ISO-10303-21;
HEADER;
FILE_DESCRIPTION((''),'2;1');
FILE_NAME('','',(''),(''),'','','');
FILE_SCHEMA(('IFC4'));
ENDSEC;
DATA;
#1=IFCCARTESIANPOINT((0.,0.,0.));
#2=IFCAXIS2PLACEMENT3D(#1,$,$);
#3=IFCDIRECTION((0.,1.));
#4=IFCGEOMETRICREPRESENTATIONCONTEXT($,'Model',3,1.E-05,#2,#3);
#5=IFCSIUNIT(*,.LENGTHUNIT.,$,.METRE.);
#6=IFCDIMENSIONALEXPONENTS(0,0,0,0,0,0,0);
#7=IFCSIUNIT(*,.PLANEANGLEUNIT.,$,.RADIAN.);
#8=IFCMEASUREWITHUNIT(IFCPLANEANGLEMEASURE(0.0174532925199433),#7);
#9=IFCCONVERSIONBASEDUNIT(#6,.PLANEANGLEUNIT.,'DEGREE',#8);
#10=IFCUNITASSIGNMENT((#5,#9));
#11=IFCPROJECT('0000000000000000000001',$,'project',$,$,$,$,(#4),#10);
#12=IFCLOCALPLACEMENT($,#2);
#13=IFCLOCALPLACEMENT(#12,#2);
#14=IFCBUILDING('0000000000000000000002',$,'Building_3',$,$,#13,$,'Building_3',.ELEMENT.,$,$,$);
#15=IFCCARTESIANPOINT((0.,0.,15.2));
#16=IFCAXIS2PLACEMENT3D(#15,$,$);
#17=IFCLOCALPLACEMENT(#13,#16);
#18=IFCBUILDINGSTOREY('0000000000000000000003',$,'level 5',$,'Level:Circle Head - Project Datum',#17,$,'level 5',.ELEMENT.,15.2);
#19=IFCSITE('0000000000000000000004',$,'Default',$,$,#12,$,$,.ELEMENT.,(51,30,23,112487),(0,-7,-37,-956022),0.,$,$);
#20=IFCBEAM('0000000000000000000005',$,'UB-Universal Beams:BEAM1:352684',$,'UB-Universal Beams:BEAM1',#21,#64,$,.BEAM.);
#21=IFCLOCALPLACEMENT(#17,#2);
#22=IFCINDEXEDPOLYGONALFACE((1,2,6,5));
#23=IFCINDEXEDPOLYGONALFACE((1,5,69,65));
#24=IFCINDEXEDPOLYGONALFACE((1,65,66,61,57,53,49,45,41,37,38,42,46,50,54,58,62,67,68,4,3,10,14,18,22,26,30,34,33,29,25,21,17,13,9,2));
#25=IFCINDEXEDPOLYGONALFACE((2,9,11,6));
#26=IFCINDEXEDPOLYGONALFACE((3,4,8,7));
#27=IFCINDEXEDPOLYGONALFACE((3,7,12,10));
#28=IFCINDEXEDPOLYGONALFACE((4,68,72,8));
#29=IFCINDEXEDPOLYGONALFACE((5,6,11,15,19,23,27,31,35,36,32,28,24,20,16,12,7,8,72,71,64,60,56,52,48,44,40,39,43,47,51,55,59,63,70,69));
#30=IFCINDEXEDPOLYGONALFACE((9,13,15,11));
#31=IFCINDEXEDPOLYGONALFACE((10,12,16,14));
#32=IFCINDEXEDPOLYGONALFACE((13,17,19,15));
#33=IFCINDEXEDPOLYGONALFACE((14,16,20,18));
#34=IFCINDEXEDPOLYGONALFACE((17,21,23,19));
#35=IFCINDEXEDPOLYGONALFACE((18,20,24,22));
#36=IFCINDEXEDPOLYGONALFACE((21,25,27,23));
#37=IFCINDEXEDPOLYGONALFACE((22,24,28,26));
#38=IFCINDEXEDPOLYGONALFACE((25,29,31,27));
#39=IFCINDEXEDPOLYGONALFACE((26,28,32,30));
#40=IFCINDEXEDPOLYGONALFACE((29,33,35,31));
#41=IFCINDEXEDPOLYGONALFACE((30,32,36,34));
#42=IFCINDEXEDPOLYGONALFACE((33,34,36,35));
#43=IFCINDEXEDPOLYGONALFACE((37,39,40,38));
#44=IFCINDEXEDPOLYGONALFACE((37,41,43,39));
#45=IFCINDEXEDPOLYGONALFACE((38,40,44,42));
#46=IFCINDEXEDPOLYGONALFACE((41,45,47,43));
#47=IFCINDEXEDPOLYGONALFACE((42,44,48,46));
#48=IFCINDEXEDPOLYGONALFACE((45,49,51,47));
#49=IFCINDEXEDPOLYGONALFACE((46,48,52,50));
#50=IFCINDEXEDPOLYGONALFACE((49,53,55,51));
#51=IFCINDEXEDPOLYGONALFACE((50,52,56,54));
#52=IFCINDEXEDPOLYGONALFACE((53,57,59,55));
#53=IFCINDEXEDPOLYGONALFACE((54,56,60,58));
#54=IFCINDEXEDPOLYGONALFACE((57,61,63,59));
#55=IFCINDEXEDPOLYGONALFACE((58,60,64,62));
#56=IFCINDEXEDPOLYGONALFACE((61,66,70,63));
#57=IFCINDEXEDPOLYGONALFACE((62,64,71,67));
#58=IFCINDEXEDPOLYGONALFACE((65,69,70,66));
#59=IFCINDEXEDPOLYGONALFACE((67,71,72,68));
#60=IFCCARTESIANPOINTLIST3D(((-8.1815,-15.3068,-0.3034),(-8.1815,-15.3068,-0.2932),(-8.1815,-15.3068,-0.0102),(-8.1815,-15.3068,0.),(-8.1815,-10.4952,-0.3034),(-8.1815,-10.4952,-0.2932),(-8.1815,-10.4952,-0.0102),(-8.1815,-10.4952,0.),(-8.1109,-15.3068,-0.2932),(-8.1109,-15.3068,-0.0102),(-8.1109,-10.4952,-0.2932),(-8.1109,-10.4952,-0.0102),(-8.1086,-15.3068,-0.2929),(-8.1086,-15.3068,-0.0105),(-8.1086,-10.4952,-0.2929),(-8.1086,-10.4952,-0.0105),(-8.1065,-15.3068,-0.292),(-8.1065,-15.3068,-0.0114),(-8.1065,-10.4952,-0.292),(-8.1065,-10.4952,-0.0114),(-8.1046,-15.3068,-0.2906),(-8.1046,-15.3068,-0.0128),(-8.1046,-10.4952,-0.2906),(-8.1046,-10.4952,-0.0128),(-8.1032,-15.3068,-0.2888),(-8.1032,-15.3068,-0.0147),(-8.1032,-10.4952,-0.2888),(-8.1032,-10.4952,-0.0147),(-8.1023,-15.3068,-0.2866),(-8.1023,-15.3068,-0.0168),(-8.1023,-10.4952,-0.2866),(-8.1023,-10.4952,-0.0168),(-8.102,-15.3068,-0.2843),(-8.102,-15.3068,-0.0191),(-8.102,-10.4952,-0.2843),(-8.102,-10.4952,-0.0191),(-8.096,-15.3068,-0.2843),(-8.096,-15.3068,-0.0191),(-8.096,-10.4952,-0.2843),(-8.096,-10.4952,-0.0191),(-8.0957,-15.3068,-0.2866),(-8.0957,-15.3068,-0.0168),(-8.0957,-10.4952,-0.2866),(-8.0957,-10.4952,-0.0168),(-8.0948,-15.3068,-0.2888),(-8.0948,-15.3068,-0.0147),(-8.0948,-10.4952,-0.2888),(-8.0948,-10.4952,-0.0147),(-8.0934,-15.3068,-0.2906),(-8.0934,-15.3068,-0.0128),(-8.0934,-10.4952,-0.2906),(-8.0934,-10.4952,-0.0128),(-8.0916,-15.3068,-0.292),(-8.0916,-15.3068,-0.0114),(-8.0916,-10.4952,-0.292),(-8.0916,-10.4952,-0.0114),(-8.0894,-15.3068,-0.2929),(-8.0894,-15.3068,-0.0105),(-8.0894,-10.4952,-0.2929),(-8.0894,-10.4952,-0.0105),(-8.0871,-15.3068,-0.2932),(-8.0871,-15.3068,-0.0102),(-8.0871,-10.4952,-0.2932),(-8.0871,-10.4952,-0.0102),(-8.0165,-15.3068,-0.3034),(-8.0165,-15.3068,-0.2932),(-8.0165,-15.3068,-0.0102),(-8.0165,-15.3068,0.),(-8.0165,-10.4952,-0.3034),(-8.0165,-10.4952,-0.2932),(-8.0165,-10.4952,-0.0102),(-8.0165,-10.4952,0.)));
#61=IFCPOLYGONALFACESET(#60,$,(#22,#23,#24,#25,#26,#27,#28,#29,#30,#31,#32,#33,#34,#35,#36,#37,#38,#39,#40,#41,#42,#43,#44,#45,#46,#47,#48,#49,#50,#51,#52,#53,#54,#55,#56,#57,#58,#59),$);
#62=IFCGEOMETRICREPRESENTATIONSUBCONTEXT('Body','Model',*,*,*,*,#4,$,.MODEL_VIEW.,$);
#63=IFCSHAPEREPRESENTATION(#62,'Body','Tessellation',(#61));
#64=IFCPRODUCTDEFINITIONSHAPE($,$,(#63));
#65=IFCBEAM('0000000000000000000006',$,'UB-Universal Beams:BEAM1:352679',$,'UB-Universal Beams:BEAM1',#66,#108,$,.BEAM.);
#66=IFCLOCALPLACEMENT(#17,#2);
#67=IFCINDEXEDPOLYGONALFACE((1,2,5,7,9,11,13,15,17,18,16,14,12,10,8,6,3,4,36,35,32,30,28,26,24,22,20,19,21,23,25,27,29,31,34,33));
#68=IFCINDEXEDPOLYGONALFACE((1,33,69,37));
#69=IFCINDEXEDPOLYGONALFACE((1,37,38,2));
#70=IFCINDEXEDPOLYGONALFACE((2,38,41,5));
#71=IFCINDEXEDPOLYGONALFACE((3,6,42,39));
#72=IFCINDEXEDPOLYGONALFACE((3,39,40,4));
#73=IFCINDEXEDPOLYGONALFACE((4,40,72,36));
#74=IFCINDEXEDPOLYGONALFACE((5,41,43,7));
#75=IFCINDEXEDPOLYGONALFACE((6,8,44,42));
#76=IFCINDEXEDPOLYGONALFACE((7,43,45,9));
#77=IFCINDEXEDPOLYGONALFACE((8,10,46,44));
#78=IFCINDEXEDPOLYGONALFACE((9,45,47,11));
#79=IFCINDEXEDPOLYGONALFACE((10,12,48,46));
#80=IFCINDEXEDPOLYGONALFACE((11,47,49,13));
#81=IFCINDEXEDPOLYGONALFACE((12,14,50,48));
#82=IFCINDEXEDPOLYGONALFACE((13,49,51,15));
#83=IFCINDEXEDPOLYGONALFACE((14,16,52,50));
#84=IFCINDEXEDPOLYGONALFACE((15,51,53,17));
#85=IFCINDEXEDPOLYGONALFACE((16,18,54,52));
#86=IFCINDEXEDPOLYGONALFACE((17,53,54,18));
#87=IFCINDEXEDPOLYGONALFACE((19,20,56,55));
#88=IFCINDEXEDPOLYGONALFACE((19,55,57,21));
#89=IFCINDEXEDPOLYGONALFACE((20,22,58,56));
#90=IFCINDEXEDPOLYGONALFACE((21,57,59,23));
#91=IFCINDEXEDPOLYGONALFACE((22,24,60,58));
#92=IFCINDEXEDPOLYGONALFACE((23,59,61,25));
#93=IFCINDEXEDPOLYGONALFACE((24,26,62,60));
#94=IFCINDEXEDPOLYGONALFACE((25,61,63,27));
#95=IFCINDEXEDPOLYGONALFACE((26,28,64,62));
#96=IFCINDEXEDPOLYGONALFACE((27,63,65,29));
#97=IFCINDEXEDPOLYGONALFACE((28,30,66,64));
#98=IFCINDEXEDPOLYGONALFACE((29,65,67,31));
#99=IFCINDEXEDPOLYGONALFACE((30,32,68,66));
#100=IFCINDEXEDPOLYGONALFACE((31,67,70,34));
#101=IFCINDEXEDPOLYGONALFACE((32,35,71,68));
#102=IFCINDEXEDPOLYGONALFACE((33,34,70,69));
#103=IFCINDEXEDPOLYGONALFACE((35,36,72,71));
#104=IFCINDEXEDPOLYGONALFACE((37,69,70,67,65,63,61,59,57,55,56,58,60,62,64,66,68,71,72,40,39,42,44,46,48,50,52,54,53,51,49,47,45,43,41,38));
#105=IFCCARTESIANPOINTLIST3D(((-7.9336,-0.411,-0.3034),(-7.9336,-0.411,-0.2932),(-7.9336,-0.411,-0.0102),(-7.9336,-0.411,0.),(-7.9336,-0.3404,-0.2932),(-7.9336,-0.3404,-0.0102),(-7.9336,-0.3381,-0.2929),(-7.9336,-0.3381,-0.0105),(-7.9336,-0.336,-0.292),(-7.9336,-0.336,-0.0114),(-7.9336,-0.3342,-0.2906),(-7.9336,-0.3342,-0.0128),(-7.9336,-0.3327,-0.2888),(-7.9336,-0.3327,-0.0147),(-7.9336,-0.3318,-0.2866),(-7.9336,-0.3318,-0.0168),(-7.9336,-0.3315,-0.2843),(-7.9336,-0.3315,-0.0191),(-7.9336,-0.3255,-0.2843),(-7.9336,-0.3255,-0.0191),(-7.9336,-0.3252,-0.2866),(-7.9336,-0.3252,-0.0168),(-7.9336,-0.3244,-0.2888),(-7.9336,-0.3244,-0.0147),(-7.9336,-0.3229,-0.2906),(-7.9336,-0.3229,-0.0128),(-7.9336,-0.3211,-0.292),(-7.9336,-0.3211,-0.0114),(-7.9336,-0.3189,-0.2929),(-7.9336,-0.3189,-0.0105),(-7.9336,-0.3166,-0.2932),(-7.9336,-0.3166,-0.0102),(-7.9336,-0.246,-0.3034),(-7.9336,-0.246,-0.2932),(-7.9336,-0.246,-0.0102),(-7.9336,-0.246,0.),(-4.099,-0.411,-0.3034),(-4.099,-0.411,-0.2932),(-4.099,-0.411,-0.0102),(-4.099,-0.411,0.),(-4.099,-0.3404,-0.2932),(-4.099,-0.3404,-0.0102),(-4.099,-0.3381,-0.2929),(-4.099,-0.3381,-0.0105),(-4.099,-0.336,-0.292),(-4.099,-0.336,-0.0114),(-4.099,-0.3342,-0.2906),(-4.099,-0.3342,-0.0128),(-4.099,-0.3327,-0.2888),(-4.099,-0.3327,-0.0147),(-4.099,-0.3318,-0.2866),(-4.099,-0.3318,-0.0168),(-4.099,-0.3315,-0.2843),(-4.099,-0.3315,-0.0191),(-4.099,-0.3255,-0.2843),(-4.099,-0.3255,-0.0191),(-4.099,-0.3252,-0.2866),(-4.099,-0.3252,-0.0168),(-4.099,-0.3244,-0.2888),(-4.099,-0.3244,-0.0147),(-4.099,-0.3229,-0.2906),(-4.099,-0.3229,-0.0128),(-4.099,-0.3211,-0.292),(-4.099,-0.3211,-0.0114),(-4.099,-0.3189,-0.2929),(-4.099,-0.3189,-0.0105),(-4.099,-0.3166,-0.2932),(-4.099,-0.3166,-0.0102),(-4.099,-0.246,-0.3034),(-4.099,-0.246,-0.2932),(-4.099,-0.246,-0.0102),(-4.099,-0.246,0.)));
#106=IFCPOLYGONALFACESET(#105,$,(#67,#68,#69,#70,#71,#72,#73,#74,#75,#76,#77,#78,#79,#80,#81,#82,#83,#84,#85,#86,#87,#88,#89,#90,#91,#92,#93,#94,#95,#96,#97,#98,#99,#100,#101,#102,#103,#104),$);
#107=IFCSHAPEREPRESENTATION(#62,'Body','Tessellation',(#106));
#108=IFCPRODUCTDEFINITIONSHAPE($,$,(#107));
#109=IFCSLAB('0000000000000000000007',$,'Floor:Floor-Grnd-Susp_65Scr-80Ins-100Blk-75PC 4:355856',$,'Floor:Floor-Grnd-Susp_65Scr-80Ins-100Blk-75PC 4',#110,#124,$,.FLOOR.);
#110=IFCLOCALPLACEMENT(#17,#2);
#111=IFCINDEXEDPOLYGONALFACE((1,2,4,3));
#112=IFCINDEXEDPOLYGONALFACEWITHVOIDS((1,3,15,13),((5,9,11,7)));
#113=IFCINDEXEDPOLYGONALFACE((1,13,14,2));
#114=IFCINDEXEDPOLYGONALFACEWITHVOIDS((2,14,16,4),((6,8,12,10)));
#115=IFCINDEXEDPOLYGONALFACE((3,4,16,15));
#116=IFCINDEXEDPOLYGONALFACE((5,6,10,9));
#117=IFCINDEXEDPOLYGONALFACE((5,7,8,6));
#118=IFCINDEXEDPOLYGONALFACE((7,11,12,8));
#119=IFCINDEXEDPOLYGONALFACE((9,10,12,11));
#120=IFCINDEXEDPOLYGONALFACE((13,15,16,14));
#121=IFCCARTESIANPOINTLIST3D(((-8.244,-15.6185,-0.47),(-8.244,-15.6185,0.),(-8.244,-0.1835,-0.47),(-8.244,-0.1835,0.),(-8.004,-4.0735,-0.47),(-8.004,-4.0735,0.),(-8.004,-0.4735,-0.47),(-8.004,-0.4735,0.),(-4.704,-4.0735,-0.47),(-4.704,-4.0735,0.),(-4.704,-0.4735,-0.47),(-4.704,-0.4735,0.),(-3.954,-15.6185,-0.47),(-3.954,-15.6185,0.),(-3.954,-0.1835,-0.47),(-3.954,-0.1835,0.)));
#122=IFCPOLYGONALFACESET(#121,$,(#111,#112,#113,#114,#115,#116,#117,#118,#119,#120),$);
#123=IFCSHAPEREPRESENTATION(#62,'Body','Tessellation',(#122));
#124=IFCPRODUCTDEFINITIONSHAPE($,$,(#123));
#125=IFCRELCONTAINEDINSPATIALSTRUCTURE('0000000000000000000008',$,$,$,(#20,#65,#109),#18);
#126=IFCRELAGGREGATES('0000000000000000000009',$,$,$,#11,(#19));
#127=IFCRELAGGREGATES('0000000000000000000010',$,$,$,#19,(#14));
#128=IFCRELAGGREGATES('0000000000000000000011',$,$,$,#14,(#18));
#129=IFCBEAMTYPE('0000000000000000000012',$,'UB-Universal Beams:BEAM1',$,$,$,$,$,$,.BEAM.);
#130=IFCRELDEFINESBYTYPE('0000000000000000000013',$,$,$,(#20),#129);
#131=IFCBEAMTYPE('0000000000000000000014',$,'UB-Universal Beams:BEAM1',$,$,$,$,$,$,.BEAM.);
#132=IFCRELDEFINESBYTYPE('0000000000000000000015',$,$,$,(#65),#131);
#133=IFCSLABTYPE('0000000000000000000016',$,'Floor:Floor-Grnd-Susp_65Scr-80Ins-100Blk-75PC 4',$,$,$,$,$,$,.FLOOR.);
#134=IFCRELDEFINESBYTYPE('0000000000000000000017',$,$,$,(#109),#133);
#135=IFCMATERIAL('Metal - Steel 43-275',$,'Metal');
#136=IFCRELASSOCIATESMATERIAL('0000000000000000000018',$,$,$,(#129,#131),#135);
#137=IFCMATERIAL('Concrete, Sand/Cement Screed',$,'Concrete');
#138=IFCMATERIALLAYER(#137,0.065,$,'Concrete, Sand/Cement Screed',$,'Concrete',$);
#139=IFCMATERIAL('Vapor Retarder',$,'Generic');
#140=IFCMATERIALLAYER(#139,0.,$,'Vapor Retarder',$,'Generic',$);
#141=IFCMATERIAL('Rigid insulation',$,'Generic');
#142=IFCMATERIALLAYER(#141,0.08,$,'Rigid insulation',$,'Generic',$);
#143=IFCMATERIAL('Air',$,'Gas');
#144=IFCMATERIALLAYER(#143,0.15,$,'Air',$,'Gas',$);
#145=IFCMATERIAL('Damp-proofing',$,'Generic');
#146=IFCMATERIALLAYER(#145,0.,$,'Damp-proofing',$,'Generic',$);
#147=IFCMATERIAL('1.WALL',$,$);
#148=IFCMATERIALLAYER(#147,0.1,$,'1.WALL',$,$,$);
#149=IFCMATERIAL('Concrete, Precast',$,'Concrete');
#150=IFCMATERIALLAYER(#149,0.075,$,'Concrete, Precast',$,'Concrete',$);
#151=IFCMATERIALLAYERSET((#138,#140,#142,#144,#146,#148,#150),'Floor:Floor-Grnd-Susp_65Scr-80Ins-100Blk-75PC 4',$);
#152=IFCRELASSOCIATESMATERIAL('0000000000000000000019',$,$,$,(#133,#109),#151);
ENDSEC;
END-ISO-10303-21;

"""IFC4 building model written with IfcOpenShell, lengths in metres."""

from ifc_helpers import new_model, entity, si_unit, converted_unit, direction, frame, frame_2d, origin, place, context, subcontext, project, spatial, polyline, circle_curve, parameter, trimmed, segment, composite_curve, rectangle, outline, extrude, boolean, source, transform, mapped, material, layer, layer_set, layer_usage, material_profile, profile_set, type_object, type_shapes, element, save


model = new_model("IFC4")

# Units and contexts
model_context = context("Model", 3, precision=1e-05, world=origin(), true_north=direction((0.0, 1.0)))
body_context = subcontext(model_context, "Body", "Model", "MODEL_VIEW")
ifc_project = project(units=[si_unit("LENGTHUNIT", "METRE"), converted_unit("PLANEANGLEUNIT", "DEGREE", entity("IfcPlaneAngleMeasure", 0.0174532925199433), si_unit("PLANEANGLEUNIT", "RADIAN"), dimensions=[0, 0, 0, 0, 0, 0, 0])], contexts=[model_context])

# Site, building, storey
site_placement = place(None, origin())
site = spatial("IfcSite", under=ifc_project, at=site_placement, Name="Default", CompositionType="ELEMENT", RefLatitude=(51, 30, 23, 112487), RefLongitude=(0, -7, -37, -956022), RefElevation=0.0)
building_placement = place(site_placement, origin())
building = spatial("IfcBuilding", under=site, at=building_placement, Name="Building_3", LongName="Building_3", CompositionType="ELEMENT")
storey_placement = place(building_placement, frame((0.0, 0.0, 15.2)))
storey = spatial("IfcBuildingStorey", under=building, at=storey_placement, Name="level 5", ObjectType="Level:Circle Head - Project Datum", LongName="level 5", CompositionType="ELEMENT", Elevation=15.2)

# Beams
ifc_material_1 = material(Name="Metal - Steel 43-275", Category="Metal")
ifc_material_profile = material_profile(ifc_material_1, outline(composite_curve([segment(polyline([(-0.0825, -0.1415), (-0.0825, -0.1517)]), True, "CONTINUOUS"), segment(polyline([(-0.0825, -0.1517), (0.0825, -0.1517)]), True, "CONTINUOUS"), segment(polyline([(0.0825, -0.1517), (0.0825, -0.1415)]), True, "CONTINUOUS"), segment(polyline([(0.0825, -0.1415), (0.0119, -0.1415)]), True, "CONTINUOUS"), segment(trimmed(circle_curve(frame_2d((0.0119, -0.1326), x_axis=(1.0, 0.0)), 0.0089), [parameter(180.0)], [parameter(270.0)], True, "PARAMETER"), False, "CONTINUOUS"), segment(polyline([(0.003, -0.1326), (0.003, 0.1326)]), True, "CONTINUOUS"), segment(trimmed(circle_curve(frame_2d((0.0119, 0.1326), x_axis=(1.0, 0.0)), 0.0089), [parameter(90.0)], [parameter(180.0)], True, "PARAMETER"), False, "CONTINUOUS"), segment(polyline([(0.0119, 0.1415), (0.0825, 0.1415)]), True, "CONTINUOUS"), segment(polyline([(0.0825, 0.1415), (0.0825, 0.1517)]), True, "CONTINUOUS"), segment(polyline([(0.0825, 0.1517), (-0.0825, 0.1517)]), True, "CONTINUOUS"), segment(polyline([(-0.0825, 0.1517), (-0.0825, 0.1415)]), True, "CONTINUOUS"), segment(polyline([(-0.0825, 0.1415), (-0.0119, 0.1415)]), True, "CONTINUOUS"), segment(trimmed(circle_curve(frame_2d((-0.0119, 0.1326), x_axis=(1.0, 0.0)), 0.0089), [parameter(360.0)], [parameter(90.0)], True, "PARAMETER"), False, "CONTINUOUS"), segment(polyline([(-0.003, 0.1326), (-0.003, -0.1326)]), True, "CONTINUOUS"), segment(trimmed(circle_curve(frame_2d((-0.0119, -0.1326), x_axis=(1.0, 0.0)), 0.0089), [parameter(270.0)], [parameter(360.0)], True, "PARAMETER"), False, "CONTINUOUS"), segment(polyline([(-0.0119, -0.1415), (-0.0825, -0.1415)]), True, "CONTINUOUS")], self_intersect=False)), Name="BEAM1")
ifc_profile_set = profile_set([ifc_material_profile], Name="BEAM1")
beam_type_1 = type_object("IfcBeamType", Name="UB-Universal Beams:BEAM1", PredefinedType="BEAM", material=ifc_profile_set)
shared_shape_1 = source(origin(), body_context, "Body", "SweptSolid", [
    extrude(outline(composite_curve([segment(polyline([(-0.0825, -0.1415), (-0.0825, -0.1517)]), True, "CONTINUOUS"), segment(polyline([(-0.0825, -0.1517), (0.0825, -0.1517)]), True, "CONTINUOUS"), segment(polyline([(0.0825, -0.1517), (0.0825, -0.1415)]), True, "CONTINUOUS"), segment(polyline([(0.0825, -0.1415), (0.0119, -0.1415)]), True, "CONTINUOUS"), segment(trimmed(circle_curve(frame_2d((0.0119, -0.1326), x_axis=(0.0, -1.0)), 0.0089), [parameter(270.0)], [parameter(360.0)], True, "PARAMETER"), False, "CONTINUOUS"), segment(polyline([(0.003, -0.1326), (0.003, 0.1326)]), True, "CONTINUOUS"), segment(trimmed(circle_curve(frame_2d((0.0119, 0.1326), x_axis=(-1.0, 0.0)), 0.0089), [parameter(270.0)], [parameter(360.0)], True, "PARAMETER"), False, "CONTINUOUS"), segment(polyline([(0.0119, 0.1415), (0.0825, 0.1415)]), True, "CONTINUOUS"), segment(polyline([(0.0825, 0.1415), (0.0825, 0.1517)]), True, "CONTINUOUS"), segment(polyline([(0.0825, 0.1517), (-0.0825, 0.1517)]), True, "CONTINUOUS"), segment(polyline([(-0.0825, 0.1517), (-0.0825, 0.1415)]), True, "CONTINUOUS"), segment(polyline([(-0.0825, 0.1415), (-0.0119, 0.1415)]), True, "CONTINUOUS"), segment(trimmed(circle_curve(frame_2d((-0.0119, 0.1326), x_axis=(0.0, 1.0)), 0.0089), [parameter(270.0)], [parameter(360.0)], True, "PARAMETER"), False, "CONTINUOUS"), segment(polyline([(-0.003, 0.1326), (-0.003, -0.1326)]), True, "CONTINUOUS"), segment(trimmed(circle_curve(frame_2d((-0.0119, -0.1326), x_axis=(1.0, 0.0)), 0.0089), [parameter(270.0)], [parameter(0.0)], True, "PARAMETER"), False, "CONTINUOUS"), segment(polyline([(-0.0119, -0.1415), (-0.0825, -0.1415)]), True, "CONTINUOUS")], self_intersect=False)), frame((-2.4058, 0.0, 0.0), z_axis=(-1.0, 0.0, 0.0), x_axis=(0.0, -1.0, 0.0)), (0.0, 0.0, -1.0), 4.8116),
])
type_shapes(beam_type_1, [shared_shape_1])
for number, where, z_axis, x_axis, name in (
    (1, (-8.099, -12.901, -0.1517), (0.0, 0.0, 1.0), (0.0, 1.0, 0.0), "UB-Universal Beams:BEAM1:352684"),
):
    element("IfcBeam", number, at=place(storey_placement, frame(where, z_axis=z_axis, x_axis=x_axis)), inside=storey, type_object=beam_type_1, Name=name, ObjectType="UB-Universal Beams:BEAM1", PredefinedType="BEAM", context=body_context, shape_type="MappedRepresentation", body=[
        mapped(shared_shape_1, transform((0.0, 0.0, 0.0), scale=1.0)),
    ])
beam_type_2 = type_object("IfcBeamType", Name="UB-Universal Beams:BEAM1", PredefinedType="BEAM", material=ifc_profile_set)
shared_shape_2 = source(origin(), body_context, "Body", "SweptSolid", [
    extrude(outline(composite_curve([segment(polyline([(-0.0825, -0.1415), (-0.0825, -0.1517)]), True, "CONTINUOUS"), segment(polyline([(-0.0825, -0.1517), (0.0825, -0.1517)]), True, "CONTINUOUS"), segment(polyline([(0.0825, -0.1517), (0.0825, -0.1415)]), True, "CONTINUOUS"), segment(polyline([(0.0825, -0.1415), (0.0119, -0.1415)]), True, "CONTINUOUS"), segment(trimmed(circle_curve(frame_2d((0.0119, -0.1326), x_axis=(1.0, 0.0)), 0.0089), [parameter(180.0)], [parameter(270.0)], True, "PARAMETER"), False, "CONTINUOUS"), segment(polyline([(0.003, -0.1326), (0.003, 0.1326)]), True, "CONTINUOUS"), segment(trimmed(circle_curve(frame_2d((0.0119, 0.1326), x_axis=(1.0, 0.0)), 0.0089), [parameter(90.0)], [parameter(180.0)], True, "PARAMETER"), False, "CONTINUOUS"), segment(polyline([(0.0119, 0.1415), (0.0825, 0.1415)]), True, "CONTINUOUS"), segment(polyline([(0.0825, 0.1415), (0.0825, 0.1517)]), True, "CONTINUOUS"), segment(polyline([(0.0825, 0.1517), (-0.0825, 0.1517)]), True, "CONTINUOUS"), segment(polyline([(-0.0825, 0.1517), (-0.0825, 0.1415)]), True, "CONTINUOUS"), segment(polyline([(-0.0825, 0.1415), (-0.0119, 0.1415)]), True, "CONTINUOUS"), segment(trimmed(circle_curve(frame_2d((-0.0119, 0.1326), x_axis=(1.0, 0.0)), 0.0089), [parameter(360.0)], [parameter(90.0)], True, "PARAMETER"), False, "CONTINUOUS"), segment(polyline([(-0.003, 0.1326), (-0.003, -0.1326)]), True, "CONTINUOUS"), segment(trimmed(circle_curve(frame_2d((-0.0119, -0.1326), x_axis=(1.0, 0.0)), 0.0089), [parameter(270.0)], [parameter(360.0)], True, "PARAMETER"), False, "CONTINUOUS"), segment(polyline([(-0.0119, -0.1415), (-0.0825, -0.1415)]), True, "CONTINUOUS")], self_intersect=False)), frame((-2.0, 0.0, 0.0), z_axis=(-1.0, 0.0, 0.0), x_axis=(0.0, -1.0, 0.0)), (0.0, 0.0, -1.0), 3.8346),
])
type_shapes(beam_type_2, [shared_shape_2])
beam_1_placement = place(storey_placement, frame((-6.099, -0.3285, -0.1517), z_axis=(0.0, 0.0, 1.0), x_axis=(-1.0, 0.0, 0.0)))
element("IfcBeam", 2, at=beam_1_placement, inside=storey, type_object=beam_type_2, Name="UB-Universal Beams:BEAM1:352679", ObjectType="UB-Universal Beams:BEAM1", PredefinedType="BEAM", context=body_context, shape_type="MappedRepresentation", body=[
    mapped(shared_shape_2, transform((0.0, 0.0, 0.0), scale=1.0)),
])

# Slab, opening
ifc_material_2 = material(Name="Concrete, Sand/Cement Screed", Category="Concrete")
ifc_layer_1 = layer(ifc_material_2, 0.065, Name="Concrete, Sand/Cement Screed", Category="Concrete")
ifc_material_3 = material(Name="Vapor Retarder", Category="Generic")
ifc_layer_2 = layer(ifc_material_3, 0.0, Name="Vapor Retarder", Category="Generic")
ifc_material_4 = material(Name="Rigid insulation", Category="Generic")
ifc_layer_3 = layer(ifc_material_4, 0.08, Name="Rigid insulation", Category="Generic")
ifc_material_5 = material(Name="Air", Category="Gas")
ifc_layer_4 = layer(ifc_material_5, 0.15, Name="Air", Category="Gas")
ifc_material_6 = material(Name="Damp-proofing", Category="Generic")
ifc_layer_5 = layer(ifc_material_6, 0.0, Name="Damp-proofing", Category="Generic")
ifc_material_7 = material(Name="1.WALL")
ifc_layer_6 = layer(ifc_material_7, 0.1, Name="1.WALL")
ifc_material_8 = material(Name="Concrete, Precast", Category="Concrete")
ifc_layer_7 = layer(ifc_material_8, 0.075, Name="Concrete, Precast", Category="Concrete")
ifc_layer_set_1 = layer_set([ifc_layer_1, ifc_layer_2, ifc_layer_3, ifc_layer_4, ifc_layer_5, ifc_layer_6, ifc_layer_7], Name="Floor:Floor-Grnd-Susp_65Scr-80Ins-100Blk-75PC 4")
ifc_layer_usage_1 = layer_usage(ifc_layer_set_1, "AXIS3", "POSITIVE", 0.0)
slab_type_1 = type_object("IfcSlabType", Name="Floor:Floor-Grnd-Susp_65Scr-80Ins-100Blk-75PC 4", PredefinedType="FLOOR", material=ifc_layer_set_1)
slab_1_placement = place(storey_placement, origin())
slab_1 = element("IfcSlab", 3, at=slab_1_placement, inside=storey, type_object=slab_type_1, material=ifc_layer_usage_1, Name="Floor:Floor-Grnd-Susp_65Scr-80Ins-100Blk-75PC 4:355856", ObjectType="Floor:Floor-Grnd-Susp_65Scr-80Ins-100Blk-75PC 4", PredefinedType="FLOOR", context=body_context, shape_type="SweptSolid", body=[
    boolean("DIFFERENCE", extrude(rectangle(XDim=15.435, YDim=4.29, at=frame_2d((0.0, 0.0), x_axis=(1.0, 0.0))), frame((-6.099, -7.901, 0.0), z_axis=(0.0, 0.0, -1.0), x_axis=(0.0, 1.0, 0.0)), (0.0, 0.0, 1.0), 0.47), extrude(rectangle(XDim=3.6, YDim=3.3, at=frame_2d((0.0, 0.0), x_axis=(1.0, 0.0))), frame((-6.354, -2.2735, -0.47), z_axis=(0.0, 0.0, 1.0), x_axis=(0.0, 1.0, 0.0)), (0.0, 0.0, 1.0), 0.47)),
])
opening_1_placement = place(slab_1_placement, origin())
element("IfcOpeningElement", 4, at=opening_1_placement, cuts=slab_1, PredefinedType="OPENING", context=body_context, shape_type="SweptSolid", body=[
    extrude(rectangle(XDim=3.6, YDim=3.3, at=frame_2d((0.0, 0.0), x_axis=(1.0, 0.0))), frame((-6.354, -2.2735, 0.0), z_axis=(0.0, 0.0, -1.0), x_axis=(0.0, -1.0, 0.0)), (0.0, 0.0, 1.0), 0.47),
])

save(model, "model.ifc")
